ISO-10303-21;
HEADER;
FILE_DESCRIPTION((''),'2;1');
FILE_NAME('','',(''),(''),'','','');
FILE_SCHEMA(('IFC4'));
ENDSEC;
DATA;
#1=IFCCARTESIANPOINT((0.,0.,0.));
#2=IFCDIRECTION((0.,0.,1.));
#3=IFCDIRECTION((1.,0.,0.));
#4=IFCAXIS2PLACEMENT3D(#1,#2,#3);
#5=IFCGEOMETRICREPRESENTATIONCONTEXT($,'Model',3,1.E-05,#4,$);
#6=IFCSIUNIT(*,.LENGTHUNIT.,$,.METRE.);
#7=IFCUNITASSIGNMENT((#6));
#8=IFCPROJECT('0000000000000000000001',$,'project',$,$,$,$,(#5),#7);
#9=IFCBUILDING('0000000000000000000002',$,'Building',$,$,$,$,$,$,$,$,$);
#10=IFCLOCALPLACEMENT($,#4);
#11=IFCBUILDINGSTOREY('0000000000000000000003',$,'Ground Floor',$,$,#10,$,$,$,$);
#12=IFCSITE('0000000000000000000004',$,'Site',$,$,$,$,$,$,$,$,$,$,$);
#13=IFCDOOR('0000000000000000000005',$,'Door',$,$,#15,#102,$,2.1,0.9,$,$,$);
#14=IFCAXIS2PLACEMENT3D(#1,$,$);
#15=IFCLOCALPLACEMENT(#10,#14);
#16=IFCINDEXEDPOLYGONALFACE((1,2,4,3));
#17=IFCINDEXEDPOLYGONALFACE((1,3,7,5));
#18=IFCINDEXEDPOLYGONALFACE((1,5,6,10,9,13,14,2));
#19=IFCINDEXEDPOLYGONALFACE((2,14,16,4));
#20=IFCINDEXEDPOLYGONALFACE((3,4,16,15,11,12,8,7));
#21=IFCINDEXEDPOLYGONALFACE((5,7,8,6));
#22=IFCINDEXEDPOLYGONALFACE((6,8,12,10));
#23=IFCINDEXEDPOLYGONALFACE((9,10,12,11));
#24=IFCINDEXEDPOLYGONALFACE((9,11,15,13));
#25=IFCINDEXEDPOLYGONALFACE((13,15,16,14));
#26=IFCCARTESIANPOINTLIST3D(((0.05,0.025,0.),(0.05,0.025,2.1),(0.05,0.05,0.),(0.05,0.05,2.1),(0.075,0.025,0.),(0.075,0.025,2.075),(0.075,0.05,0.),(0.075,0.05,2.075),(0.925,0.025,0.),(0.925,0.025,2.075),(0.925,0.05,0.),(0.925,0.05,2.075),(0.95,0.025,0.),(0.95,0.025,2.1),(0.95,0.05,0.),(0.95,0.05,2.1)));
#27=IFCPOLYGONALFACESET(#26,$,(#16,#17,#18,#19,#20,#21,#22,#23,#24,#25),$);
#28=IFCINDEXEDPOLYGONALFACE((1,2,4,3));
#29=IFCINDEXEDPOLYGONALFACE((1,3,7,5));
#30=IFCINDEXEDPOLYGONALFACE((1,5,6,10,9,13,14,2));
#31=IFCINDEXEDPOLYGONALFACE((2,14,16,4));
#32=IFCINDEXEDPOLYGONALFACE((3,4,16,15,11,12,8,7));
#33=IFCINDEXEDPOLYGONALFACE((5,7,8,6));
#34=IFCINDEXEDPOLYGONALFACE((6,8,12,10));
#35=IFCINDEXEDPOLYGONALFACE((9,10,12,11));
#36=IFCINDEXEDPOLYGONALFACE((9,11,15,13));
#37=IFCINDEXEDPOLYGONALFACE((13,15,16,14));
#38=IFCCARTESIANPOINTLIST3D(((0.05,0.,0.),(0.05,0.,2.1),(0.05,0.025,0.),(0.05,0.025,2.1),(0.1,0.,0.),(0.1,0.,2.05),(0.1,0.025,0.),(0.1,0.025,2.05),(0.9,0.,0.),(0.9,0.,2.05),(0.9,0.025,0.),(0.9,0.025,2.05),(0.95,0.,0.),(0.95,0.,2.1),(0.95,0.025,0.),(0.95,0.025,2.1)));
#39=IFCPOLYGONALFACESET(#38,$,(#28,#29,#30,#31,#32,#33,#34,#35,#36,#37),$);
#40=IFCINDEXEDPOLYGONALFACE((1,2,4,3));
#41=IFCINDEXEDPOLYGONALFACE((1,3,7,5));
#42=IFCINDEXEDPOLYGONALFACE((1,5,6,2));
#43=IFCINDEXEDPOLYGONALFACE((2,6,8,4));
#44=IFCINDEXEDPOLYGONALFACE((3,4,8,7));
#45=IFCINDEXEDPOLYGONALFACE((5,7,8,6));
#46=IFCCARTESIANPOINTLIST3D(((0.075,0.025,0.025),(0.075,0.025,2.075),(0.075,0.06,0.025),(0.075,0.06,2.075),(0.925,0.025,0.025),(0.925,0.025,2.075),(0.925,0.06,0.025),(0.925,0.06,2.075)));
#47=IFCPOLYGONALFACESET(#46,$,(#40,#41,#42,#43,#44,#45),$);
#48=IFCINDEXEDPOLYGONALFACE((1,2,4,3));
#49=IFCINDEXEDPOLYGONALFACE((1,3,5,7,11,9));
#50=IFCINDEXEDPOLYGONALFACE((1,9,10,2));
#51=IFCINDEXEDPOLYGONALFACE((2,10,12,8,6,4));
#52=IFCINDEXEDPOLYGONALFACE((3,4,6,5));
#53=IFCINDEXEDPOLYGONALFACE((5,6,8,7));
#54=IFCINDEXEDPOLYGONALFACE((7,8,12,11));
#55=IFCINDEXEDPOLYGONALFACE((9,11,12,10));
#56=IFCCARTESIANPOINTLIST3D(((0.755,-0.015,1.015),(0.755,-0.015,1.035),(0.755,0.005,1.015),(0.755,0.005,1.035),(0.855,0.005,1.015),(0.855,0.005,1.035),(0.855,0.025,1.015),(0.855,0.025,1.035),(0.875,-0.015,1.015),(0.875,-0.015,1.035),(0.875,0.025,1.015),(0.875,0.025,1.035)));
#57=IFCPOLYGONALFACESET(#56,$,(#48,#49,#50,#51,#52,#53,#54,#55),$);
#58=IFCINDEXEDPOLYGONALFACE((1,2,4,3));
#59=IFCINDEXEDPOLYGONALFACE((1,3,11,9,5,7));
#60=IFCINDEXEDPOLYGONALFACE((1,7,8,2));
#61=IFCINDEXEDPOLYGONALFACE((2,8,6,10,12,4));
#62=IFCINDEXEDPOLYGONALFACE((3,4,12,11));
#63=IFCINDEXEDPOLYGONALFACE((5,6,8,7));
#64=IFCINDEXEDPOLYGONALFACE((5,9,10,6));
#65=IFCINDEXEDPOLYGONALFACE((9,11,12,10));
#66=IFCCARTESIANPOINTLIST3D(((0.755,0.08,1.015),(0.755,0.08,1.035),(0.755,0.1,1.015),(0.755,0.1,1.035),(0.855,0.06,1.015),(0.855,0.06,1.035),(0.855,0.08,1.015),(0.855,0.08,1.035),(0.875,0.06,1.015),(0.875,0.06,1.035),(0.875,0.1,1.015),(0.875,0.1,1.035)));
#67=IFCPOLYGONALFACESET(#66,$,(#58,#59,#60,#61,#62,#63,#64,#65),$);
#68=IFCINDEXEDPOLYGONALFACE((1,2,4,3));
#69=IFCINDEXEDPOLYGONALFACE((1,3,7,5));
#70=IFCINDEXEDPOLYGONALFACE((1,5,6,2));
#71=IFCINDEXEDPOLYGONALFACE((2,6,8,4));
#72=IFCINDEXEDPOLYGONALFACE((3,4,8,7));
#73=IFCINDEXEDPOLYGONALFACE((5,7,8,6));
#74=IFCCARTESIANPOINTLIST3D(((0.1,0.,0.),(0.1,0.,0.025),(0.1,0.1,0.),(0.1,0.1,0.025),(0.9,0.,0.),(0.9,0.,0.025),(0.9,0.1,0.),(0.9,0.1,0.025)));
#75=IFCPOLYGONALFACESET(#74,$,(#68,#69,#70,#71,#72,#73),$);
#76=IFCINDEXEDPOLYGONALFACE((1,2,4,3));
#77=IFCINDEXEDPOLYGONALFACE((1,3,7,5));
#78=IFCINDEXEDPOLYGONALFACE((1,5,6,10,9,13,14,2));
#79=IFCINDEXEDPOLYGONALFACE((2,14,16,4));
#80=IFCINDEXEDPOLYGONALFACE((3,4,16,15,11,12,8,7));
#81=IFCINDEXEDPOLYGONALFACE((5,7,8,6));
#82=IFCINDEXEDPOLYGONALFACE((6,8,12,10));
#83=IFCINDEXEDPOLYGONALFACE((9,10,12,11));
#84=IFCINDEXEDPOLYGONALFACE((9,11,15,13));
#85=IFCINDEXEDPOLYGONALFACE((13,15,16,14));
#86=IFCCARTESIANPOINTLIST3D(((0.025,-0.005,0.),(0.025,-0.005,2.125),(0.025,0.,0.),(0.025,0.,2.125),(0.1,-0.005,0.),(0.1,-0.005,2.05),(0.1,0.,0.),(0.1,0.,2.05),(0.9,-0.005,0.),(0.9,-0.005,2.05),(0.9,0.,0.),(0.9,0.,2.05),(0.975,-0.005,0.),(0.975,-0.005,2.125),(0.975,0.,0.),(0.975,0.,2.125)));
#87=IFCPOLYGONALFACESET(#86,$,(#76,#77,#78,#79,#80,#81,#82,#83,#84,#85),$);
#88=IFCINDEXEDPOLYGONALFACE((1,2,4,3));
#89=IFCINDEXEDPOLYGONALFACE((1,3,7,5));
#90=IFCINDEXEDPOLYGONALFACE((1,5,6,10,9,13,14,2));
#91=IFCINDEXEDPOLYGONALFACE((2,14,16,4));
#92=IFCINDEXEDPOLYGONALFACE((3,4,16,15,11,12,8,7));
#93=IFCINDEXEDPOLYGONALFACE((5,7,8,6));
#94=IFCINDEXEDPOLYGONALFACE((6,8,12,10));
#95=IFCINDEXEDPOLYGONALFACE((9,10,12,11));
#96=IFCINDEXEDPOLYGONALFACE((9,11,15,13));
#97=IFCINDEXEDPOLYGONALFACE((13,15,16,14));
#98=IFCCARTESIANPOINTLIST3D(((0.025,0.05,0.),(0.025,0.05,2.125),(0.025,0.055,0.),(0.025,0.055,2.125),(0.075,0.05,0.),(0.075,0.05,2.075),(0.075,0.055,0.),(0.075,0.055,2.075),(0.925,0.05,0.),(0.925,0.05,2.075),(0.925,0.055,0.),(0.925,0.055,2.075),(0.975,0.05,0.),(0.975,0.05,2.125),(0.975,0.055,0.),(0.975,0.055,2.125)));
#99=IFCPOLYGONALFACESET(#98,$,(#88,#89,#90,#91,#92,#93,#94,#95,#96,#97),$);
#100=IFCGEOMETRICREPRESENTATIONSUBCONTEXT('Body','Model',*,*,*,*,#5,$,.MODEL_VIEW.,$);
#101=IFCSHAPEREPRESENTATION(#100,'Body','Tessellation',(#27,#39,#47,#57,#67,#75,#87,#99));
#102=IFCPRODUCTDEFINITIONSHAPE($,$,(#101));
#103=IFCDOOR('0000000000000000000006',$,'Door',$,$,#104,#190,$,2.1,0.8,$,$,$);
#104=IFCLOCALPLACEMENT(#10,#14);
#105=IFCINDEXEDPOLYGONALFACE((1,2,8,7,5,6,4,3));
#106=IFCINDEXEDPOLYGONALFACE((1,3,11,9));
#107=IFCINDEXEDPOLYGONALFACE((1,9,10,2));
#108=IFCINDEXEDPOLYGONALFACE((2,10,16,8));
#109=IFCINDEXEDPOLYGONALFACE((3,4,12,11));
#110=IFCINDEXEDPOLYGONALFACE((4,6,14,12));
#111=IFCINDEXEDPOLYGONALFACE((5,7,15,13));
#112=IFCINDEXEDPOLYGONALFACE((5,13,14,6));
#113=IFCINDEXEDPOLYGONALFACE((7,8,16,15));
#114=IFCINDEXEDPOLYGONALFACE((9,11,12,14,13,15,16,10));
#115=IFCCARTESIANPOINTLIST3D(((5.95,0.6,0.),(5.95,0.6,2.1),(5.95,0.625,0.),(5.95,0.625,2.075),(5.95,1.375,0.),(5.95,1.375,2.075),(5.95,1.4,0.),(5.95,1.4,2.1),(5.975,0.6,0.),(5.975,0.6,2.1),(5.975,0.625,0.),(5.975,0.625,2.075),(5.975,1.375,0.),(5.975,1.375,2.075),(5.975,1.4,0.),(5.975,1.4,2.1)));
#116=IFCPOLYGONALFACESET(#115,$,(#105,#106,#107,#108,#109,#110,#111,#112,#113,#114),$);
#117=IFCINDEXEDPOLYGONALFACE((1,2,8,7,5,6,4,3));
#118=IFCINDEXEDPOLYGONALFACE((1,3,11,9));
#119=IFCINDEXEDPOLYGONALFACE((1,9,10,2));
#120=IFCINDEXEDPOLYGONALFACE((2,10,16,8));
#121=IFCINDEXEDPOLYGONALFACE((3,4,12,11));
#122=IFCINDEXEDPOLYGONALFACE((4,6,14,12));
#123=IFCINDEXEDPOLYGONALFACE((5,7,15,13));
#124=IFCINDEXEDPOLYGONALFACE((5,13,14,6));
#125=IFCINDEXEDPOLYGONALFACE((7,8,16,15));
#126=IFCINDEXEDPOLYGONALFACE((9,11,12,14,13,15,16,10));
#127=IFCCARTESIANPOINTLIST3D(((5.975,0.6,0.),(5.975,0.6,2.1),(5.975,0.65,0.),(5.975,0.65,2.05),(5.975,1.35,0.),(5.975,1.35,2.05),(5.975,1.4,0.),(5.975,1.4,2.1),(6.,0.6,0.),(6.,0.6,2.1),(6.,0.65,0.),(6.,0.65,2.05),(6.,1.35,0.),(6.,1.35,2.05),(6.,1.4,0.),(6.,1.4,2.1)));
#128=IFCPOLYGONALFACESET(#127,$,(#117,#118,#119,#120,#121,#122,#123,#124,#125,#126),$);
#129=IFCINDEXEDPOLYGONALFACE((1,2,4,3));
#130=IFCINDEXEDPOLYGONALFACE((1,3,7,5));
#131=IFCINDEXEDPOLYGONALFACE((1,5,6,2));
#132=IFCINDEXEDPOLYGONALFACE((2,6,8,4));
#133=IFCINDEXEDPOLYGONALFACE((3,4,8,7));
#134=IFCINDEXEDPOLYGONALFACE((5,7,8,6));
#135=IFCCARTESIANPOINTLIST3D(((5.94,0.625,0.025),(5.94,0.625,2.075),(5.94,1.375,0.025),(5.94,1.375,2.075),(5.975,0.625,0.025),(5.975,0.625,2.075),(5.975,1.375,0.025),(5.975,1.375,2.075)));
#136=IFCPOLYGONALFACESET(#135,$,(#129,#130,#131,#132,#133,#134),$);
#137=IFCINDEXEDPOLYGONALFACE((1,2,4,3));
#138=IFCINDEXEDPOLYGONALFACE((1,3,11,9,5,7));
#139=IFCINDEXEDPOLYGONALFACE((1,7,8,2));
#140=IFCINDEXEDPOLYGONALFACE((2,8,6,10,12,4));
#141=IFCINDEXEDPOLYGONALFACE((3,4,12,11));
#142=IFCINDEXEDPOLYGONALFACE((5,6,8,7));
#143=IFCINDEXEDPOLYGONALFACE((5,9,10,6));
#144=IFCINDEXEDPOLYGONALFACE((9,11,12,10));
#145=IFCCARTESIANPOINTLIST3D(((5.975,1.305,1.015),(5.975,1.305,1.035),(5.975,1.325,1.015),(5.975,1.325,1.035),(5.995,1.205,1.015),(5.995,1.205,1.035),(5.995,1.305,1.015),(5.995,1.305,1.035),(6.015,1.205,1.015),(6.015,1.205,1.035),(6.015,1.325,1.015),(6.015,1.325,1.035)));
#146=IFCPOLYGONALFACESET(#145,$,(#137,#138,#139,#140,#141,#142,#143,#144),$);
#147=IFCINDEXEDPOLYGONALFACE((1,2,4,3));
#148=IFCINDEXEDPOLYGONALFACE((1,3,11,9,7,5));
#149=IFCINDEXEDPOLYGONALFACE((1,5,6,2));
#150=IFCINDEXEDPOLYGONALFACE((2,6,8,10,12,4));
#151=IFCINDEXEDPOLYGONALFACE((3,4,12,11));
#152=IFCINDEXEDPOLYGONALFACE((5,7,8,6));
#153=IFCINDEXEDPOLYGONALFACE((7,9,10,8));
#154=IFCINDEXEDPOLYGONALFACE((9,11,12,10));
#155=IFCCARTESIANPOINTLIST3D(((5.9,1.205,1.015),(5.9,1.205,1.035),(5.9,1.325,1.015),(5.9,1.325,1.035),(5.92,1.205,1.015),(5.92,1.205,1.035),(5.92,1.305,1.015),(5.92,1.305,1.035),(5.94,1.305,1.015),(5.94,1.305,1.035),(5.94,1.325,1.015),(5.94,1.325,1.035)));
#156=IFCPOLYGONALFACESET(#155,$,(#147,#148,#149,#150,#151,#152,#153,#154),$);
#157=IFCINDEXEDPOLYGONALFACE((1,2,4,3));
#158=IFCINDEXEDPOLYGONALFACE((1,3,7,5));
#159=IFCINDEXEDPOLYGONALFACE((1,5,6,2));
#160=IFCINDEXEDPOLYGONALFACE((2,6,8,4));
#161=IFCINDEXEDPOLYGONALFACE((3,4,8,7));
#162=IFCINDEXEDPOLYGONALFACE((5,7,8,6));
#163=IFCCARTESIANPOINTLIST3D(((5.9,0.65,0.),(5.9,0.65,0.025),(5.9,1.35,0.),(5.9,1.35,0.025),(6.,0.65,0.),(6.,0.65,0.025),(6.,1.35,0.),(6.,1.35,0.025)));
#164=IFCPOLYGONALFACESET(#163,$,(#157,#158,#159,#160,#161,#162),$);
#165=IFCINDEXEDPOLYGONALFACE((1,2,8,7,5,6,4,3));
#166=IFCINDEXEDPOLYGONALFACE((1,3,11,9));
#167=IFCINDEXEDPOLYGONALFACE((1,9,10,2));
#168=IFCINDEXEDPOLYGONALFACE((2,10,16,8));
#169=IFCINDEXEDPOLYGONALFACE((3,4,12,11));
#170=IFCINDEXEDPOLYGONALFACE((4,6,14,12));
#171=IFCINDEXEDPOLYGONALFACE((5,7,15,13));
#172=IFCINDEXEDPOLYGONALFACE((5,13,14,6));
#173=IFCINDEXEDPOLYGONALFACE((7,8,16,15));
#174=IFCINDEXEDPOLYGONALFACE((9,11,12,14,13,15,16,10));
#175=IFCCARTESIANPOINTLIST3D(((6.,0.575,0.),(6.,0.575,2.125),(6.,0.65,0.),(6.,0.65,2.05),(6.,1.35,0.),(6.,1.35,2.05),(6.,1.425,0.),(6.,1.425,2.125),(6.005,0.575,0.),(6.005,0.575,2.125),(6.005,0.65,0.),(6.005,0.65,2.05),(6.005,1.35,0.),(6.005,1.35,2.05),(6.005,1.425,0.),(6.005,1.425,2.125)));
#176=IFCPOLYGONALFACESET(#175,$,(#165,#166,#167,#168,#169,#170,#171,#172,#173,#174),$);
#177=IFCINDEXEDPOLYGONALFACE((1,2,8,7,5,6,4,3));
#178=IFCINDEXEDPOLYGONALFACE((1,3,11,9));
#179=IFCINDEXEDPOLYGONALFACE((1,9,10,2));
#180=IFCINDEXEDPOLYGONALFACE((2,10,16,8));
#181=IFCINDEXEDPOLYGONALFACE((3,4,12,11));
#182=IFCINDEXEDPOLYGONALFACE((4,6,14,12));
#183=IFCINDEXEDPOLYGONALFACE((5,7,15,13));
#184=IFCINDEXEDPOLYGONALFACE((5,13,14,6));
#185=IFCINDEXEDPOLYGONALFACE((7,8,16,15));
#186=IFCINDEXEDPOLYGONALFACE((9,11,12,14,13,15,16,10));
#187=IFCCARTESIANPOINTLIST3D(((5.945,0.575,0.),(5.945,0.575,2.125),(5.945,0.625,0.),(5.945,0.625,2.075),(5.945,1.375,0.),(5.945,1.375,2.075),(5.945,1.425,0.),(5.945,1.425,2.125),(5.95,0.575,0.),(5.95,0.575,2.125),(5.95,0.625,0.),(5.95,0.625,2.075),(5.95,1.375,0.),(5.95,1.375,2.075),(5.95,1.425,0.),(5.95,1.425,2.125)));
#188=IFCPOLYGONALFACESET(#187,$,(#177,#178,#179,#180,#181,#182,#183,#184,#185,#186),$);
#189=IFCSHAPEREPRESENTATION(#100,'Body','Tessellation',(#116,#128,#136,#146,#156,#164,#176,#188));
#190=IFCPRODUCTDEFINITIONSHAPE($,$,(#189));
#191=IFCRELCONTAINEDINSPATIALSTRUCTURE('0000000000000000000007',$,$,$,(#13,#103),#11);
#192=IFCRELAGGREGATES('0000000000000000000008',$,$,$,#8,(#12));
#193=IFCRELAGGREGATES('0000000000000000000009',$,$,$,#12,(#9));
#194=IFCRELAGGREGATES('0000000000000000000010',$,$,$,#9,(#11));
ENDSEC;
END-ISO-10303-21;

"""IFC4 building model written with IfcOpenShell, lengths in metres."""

from ifc_helpers import new_model, si_unit, frame, origin_with_axes, place, context, subcontext, project, spatial, line, indexed_curve, outline, extrude, element, save


model = new_model("IFC4")

# Units and contexts
model_context = context("Model", 3, precision=1e-05, world=origin_with_axes())
body_context = subcontext(model_context, "Body", "Model", "MODEL_VIEW")
ifc_project = project(units=[si_unit("LENGTHUNIT", "METRE")], contexts=[model_context])

# Site, building, storey
site = spatial("IfcSite", under=ifc_project, Name="Site")
building = spatial("IfcBuilding", under=site, Name="Building")
storey_placement = place(None, origin_with_axes())
storey = spatial("IfcBuildingStorey", under=building, at=storey_placement, Name="Ground Floor")

# Doors
door_1_placement = place(storey_placement, frame((0.05, 0.0, 0.0), z_axis=(0.0, 0.0, 1.0), x_axis=(1.0, 0.0, 0.0)))
element("IfcDoor", 1, at=door_1_placement, inside=storey, Name="Door", OverallHeight=2.1, OverallWidth=0.9, context=body_context, shape_type="SweptSolid", body=[
    extrude(outline(indexed_curve([(0.0, 0.0), (0.0, 2.1), (0.9, 2.1), (0.9, 0.0), (0.875, 0.0), (0.875, 2.075), (0.025, 2.075), (0.025, 0.0)], segments=[line(1, 2, 3, 4, 5, 6, 7, 8, 1)])), frame((0.0, 0.025, 0.0), z_axis=(0.0, -1.0, 0.0), x_axis=(1.0, 0.0, 0.0)), (0.0, 0.0, -1.0), 0.025),
    extrude(outline(indexed_curve([(0.0, 0.0), (0.0, 2.1), (0.9, 2.1), (0.9, 0.0), (0.85, 0.0), (0.85, 2.05), (0.05, 2.05), (0.05, 0.0)], segments=[line(1, 2, 3, 4, 5, 6, 7, 8, 1)])), frame((0.0, 0.0, 0.0), z_axis=(0.0, -1.0, 0.0), x_axis=(1.0, 0.0, 0.0)), (0.0, 0.0, -1.0), 0.025),
    extrude(outline(indexed_curve([(0.0, 0.0), (0.85, 0.0), (0.85, 0.035), (0.0, 0.035)], segments=[line(1, 2, 3, 4, 1)])), frame((0.025, 0.025, 0.025), z_axis=(0.0, 0.0, 1.0), x_axis=(1.0, 0.0, 0.0)), (0.0, 0.0, 1.0), 2.05),
    extrude(outline(indexed_curve([(0.0, 0.0), (0.0, -0.04), (-0.12, -0.04), (-0.12, -0.02), (-0.02, -0.02), (-0.02, 0.0)], segments=[line(1, 2, 3, 4, 5, 6, 1)])), frame((0.825, 0.025, 1.015), z_axis=(0.0, 0.0, 1.0), x_axis=(1.0, 0.0, 0.0)), (0.0, 0.0, 1.0), 0.02),
    extrude(outline(indexed_curve([(0.0, 0.0), (0.0, 0.04), (-0.12, 0.04), (-0.12, 0.02), (-0.02, 0.02), (-0.02, 0.0)], segments=[line(1, 2, 3, 4, 5, 6, 1)])), frame((0.825, 0.06, 1.015), z_axis=(0.0, 0.0, 1.0), x_axis=(1.0, 0.0, 0.0)), (0.0, 0.0, 1.0), 0.02),
    extrude(outline(indexed_curve([(0.0, 0.0), (0.8, 0.0), (0.8, 0.1), (0.0, 0.1)], segments=[line(1, 2, 3, 4, 1)])), frame((0.05, 0.0, 0.0), z_axis=(0.0, 0.0, 1.0), x_axis=(1.0, 0.0, 0.0)), (0.0, 0.0, 1.0), 0.025),
    extrude(outline(indexed_curve([(0.0, 0.0), (0.0, 2.125), (0.95, 2.125), (0.95, 0.0), (0.875, 0.0), (0.875, 2.05), (0.075, 2.05), (0.075, 0.0)], segments=[line(1, 2, 3, 4, 5, 6, 7, 8, 1)])), frame((-0.025, -0.005, 0.0), z_axis=(0.0, -1.0, 0.0), x_axis=(1.0, 0.0, 0.0)), (0.0, 0.0, -1.0), 0.005),
    extrude(outline(indexed_curve([(0.0, 0.0), (0.0, 2.125), (0.95, 2.125), (0.95, 0.0), (0.9, 0.0), (0.9, 2.075), (0.05, 2.075), (0.05, 0.0)], segments=[line(1, 2, 3, 4, 5, 6, 7, 8, 1)])), frame((-0.025, 0.05, 0.0), z_axis=(0.0, -1.0, 0.0), x_axis=(1.0, 0.0, 0.0)), (0.0, 0.0, -1.0), 0.005),
])
door_2_placement = place(storey_placement, frame((6.0, 0.6, 0.0), z_axis=(0.0, 0.0, 1.0), x_axis=(0.0, 1.0, 0.0)))
element("IfcDoor", 2, at=door_2_placement, inside=storey, Name="Door", OverallHeight=2.1, OverallWidth=0.8, context=body_context, shape_type="SweptSolid", body=[
    extrude(outline(indexed_curve([(0.0, 0.0), (0.0, 2.1), (0.8, 2.1), (0.8, 0.0), (0.775, 0.0), (0.775, 2.075), (0.025, 2.075), (0.025, 0.0)], segments=[line(1, 2, 3, 4, 5, 6, 7, 8, 1)])), frame((0.0, 0.025, 0.0), z_axis=(0.0, -1.0, 0.0), x_axis=(1.0, 0.0, 0.0)), (0.0, 0.0, -1.0), 0.025),
    extrude(outline(indexed_curve([(0.0, 0.0), (0.0, 2.1), (0.8, 2.1), (0.8, 0.0), (0.75, 0.0), (0.75, 2.05), (0.05, 2.05), (0.05, 0.0)], segments=[line(1, 2, 3, 4, 5, 6, 7, 8, 1)])), frame((0.0, 0.0, 0.0), z_axis=(0.0, -1.0, 0.0), x_axis=(1.0, 0.0, 0.0)), (0.0, 0.0, -1.0), 0.025),
    extrude(outline(indexed_curve([(0.0, 0.0), (0.75, 0.0), (0.75, 0.035), (0.0, 0.035)], segments=[line(1, 2, 3, 4, 1)])), frame((0.025, 0.025, 0.025), z_axis=(0.0, 0.0, 1.0), x_axis=(1.0, 0.0, 0.0)), (0.0, 0.0, 1.0), 2.05),
    extrude(outline(indexed_curve([(0.0, 0.0), (0.0, -0.04), (-0.12, -0.04), (-0.12, -0.02), (-0.02, -0.02), (-0.02, 0.0)], segments=[line(1, 2, 3, 4, 5, 6, 1)])), frame((0.725, 0.025, 1.015), z_axis=(0.0, 0.0, 1.0), x_axis=(1.0, 0.0, 0.0)), (0.0, 0.0, 1.0), 0.02),
    extrude(outline(indexed_curve([(0.0, 0.0), (0.0, 0.04), (-0.12, 0.04), (-0.12, 0.02), (-0.02, 0.02), (-0.02, 0.0)], segments=[line(1, 2, 3, 4, 5, 6, 1)])), frame((0.725, 0.06, 1.015), z_axis=(0.0, 0.0, 1.0), x_axis=(1.0, 0.0, 0.0)), (0.0, 0.0, 1.0), 0.02),
    extrude(outline(indexed_curve([(0.0, 0.0), (0.7, 0.0), (0.7, 0.1), (0.0, 0.1)], segments=[line(1, 2, 3, 4, 1)])), frame((0.05, 0.0, 0.0), z_axis=(0.0, 0.0, 1.0), x_axis=(1.0, 0.0, 0.0)), (0.0, 0.0, 1.0), 0.025),
    extrude(outline(indexed_curve([(0.0, 0.0), (0.0, 2.125), (0.85, 2.125), (0.85, 0.0), (0.775, 0.0), (0.775, 2.05), (0.075, 2.05), (0.075, 0.0)], segments=[line(1, 2, 3, 4, 5, 6, 7, 8, 1)])), frame((-0.025, -0.005, 0.0), z_axis=(0.0, -1.0, 0.0), x_axis=(1.0, 0.0, 0.0)), (0.0, 0.0, -1.0), 0.005),
    extrude(outline(indexed_curve([(0.0, 0.0), (0.0, 2.125), (0.85, 2.125), (0.85, 0.0), (0.8, 0.0), (0.8, 2.075), (0.05, 2.075), (0.05, 0.0)], segments=[line(1, 2, 3, 4, 5, 6, 7, 8, 1)])), frame((-0.025, 0.05, 0.0), z_axis=(0.0, -1.0, 0.0), x_axis=(1.0, 0.0, 0.0)), (0.0, 0.0, -1.0), 0.005),
])

save(model, "model.ifc")
